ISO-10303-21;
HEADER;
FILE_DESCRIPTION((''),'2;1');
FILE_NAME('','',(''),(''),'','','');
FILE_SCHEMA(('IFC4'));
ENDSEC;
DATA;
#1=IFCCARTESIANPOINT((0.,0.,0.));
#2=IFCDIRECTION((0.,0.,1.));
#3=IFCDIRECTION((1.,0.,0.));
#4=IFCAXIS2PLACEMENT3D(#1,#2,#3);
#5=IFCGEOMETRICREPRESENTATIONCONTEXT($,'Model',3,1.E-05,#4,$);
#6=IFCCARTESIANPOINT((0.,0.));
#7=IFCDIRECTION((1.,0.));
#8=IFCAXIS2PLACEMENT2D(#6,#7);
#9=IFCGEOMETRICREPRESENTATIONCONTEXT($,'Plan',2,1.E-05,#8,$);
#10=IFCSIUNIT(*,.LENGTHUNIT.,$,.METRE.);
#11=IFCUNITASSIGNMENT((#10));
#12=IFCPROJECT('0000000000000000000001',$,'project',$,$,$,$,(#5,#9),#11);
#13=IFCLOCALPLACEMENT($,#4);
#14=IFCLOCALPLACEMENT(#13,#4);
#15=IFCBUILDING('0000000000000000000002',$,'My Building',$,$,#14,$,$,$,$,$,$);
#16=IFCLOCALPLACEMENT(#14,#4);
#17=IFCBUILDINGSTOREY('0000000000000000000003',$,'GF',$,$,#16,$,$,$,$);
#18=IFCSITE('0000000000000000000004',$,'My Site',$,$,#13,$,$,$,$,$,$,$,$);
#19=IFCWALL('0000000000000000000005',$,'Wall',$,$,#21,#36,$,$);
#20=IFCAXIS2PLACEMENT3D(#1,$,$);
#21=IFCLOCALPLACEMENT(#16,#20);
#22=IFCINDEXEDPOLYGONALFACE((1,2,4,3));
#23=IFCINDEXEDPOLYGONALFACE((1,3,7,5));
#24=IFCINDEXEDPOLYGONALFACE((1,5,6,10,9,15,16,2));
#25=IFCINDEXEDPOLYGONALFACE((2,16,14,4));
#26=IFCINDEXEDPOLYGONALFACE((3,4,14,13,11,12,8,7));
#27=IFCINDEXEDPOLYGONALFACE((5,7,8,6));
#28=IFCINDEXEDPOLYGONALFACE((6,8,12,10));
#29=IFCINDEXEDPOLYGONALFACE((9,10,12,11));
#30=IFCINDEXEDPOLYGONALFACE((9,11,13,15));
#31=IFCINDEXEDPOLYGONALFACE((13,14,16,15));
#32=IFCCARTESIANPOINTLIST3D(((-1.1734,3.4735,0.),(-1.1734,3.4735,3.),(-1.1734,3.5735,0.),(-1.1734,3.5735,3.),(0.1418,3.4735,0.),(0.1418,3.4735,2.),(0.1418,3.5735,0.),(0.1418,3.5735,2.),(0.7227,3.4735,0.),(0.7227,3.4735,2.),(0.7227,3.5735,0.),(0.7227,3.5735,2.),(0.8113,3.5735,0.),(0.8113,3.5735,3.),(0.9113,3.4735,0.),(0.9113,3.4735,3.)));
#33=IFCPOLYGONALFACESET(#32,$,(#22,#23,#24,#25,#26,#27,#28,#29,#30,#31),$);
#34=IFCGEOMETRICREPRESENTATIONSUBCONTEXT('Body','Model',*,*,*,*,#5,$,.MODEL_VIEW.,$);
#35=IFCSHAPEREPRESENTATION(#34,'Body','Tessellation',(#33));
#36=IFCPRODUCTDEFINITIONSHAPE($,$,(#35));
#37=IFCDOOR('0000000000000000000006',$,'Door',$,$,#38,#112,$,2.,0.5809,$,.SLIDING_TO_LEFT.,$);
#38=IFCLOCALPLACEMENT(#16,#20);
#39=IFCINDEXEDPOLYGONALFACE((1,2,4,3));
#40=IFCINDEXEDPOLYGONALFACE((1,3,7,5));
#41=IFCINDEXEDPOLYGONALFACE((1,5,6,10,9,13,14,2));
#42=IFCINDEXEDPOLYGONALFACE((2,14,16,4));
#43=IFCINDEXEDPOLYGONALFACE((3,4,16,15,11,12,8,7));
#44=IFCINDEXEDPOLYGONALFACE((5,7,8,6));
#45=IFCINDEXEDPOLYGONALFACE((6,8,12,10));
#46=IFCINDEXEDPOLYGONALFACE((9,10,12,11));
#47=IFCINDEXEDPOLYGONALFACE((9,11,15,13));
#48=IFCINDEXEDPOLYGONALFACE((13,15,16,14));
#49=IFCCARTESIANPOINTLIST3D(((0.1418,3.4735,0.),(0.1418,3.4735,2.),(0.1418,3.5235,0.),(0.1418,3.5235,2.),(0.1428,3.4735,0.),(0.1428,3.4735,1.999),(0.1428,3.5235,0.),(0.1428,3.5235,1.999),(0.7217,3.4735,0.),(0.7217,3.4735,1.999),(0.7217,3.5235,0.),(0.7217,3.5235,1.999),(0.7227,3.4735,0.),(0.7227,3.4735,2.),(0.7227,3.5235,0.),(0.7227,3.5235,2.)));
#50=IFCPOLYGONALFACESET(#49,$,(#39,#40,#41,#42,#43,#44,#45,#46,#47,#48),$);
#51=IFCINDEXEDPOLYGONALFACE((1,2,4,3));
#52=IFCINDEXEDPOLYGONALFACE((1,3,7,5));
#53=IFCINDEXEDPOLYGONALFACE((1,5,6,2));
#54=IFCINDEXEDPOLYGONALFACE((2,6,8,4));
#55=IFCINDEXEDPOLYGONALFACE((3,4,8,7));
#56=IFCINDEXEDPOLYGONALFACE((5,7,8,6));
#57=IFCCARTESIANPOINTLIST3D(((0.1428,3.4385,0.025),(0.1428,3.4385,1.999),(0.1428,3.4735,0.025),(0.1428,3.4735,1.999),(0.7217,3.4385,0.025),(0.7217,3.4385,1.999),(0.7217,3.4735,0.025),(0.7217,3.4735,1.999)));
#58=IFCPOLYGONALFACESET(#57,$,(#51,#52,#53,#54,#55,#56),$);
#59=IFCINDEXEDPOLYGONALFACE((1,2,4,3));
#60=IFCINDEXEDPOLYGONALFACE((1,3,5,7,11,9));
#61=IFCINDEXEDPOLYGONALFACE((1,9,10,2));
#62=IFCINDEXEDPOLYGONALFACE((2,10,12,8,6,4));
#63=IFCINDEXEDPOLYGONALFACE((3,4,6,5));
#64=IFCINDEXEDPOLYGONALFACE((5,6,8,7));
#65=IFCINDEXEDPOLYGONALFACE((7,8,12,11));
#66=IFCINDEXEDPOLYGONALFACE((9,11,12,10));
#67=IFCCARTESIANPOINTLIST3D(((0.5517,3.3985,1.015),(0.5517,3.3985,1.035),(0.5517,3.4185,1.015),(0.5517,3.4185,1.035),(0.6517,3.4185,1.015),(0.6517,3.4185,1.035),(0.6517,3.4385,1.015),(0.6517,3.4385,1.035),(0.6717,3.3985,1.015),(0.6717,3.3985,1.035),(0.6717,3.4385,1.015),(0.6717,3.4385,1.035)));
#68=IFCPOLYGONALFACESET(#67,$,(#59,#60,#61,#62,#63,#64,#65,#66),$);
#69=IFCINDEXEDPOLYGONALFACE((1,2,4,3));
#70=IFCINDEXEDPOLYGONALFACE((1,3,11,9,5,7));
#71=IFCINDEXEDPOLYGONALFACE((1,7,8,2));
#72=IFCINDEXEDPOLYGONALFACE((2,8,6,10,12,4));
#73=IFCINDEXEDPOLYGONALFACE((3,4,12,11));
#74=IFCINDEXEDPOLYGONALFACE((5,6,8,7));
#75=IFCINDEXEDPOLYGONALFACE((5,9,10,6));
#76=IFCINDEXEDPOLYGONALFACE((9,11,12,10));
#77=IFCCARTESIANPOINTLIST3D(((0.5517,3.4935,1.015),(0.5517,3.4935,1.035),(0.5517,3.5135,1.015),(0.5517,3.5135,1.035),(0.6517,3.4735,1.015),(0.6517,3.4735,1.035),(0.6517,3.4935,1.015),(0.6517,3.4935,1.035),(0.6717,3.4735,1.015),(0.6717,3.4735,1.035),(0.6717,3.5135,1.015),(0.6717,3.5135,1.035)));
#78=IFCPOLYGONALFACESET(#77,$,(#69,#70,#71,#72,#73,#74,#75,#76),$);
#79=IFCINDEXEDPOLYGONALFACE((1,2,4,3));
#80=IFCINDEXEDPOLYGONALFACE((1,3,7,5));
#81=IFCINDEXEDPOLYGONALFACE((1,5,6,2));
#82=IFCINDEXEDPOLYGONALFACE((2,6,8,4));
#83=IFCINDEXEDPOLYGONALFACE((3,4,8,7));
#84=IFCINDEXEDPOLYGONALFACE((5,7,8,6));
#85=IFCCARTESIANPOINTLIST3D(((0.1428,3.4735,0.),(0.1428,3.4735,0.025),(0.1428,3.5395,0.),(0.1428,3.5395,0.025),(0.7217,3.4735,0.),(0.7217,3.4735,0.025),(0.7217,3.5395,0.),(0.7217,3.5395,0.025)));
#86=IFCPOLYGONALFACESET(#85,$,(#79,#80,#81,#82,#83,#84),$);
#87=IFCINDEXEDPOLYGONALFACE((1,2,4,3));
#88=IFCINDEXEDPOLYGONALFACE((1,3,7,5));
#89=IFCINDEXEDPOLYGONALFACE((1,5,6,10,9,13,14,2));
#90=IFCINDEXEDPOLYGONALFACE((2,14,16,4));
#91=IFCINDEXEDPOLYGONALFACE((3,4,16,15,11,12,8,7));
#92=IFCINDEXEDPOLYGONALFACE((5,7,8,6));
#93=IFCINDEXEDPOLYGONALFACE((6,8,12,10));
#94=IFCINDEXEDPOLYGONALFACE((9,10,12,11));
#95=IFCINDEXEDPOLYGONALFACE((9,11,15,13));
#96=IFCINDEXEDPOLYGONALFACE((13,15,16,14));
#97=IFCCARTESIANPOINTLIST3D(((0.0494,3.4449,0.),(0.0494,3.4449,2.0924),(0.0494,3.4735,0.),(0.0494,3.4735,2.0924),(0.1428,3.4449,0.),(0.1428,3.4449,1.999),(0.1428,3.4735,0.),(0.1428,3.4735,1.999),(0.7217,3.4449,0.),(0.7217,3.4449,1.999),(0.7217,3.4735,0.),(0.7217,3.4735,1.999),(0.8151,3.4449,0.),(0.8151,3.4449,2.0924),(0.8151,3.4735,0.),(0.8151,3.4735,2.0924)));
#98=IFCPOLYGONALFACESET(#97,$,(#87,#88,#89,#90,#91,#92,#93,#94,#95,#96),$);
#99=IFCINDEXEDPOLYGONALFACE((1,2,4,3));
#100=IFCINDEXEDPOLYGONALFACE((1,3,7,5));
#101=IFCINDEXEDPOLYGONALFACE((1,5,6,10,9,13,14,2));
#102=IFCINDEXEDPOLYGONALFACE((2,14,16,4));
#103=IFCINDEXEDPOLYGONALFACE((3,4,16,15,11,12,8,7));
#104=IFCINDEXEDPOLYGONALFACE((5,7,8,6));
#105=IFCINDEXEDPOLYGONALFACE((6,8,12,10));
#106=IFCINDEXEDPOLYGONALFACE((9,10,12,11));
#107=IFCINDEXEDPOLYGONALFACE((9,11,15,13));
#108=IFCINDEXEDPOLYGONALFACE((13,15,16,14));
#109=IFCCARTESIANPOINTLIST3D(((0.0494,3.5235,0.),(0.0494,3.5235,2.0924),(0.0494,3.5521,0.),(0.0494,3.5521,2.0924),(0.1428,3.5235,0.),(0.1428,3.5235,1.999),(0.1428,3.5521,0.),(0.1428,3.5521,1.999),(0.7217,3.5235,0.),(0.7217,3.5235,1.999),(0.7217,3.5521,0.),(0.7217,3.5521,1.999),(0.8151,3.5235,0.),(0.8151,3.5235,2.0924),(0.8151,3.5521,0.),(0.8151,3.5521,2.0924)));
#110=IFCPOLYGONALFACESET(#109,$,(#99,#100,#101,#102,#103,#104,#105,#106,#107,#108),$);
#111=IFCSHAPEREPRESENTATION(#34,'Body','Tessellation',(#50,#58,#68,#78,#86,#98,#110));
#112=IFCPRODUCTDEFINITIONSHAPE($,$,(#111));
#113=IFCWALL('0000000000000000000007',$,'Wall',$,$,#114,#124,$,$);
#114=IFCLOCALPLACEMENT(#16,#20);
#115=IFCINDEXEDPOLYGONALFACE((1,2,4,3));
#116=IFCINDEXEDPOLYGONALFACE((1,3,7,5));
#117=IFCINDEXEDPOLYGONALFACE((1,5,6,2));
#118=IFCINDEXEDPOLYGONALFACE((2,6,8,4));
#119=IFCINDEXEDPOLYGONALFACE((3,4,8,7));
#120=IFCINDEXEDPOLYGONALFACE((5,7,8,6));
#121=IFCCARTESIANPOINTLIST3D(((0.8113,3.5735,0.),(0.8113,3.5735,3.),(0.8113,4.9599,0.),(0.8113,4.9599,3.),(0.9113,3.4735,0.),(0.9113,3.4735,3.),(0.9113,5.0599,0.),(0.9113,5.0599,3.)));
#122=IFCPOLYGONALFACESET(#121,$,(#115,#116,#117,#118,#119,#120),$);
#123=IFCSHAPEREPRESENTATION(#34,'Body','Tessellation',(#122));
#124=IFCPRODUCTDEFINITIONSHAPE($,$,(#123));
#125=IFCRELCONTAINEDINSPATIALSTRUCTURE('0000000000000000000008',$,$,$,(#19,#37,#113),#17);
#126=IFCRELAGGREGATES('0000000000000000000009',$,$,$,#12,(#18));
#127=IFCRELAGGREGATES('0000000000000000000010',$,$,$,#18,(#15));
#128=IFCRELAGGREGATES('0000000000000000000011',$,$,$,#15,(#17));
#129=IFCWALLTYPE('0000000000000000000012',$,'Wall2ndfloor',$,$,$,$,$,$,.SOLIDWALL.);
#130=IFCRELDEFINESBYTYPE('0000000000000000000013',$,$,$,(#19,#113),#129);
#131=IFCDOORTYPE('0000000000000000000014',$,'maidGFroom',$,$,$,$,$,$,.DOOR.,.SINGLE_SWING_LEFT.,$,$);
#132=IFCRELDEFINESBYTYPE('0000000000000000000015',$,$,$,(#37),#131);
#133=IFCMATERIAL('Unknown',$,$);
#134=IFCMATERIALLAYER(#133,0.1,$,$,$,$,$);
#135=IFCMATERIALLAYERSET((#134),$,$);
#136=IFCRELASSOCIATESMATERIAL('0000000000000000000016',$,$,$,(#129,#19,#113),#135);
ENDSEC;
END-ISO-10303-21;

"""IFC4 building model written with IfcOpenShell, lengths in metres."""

from ifc_helpers import new_model, entity, si_unit, frame, origin_with_axes, origin_2d_with_axis, place, context, subcontext, project, spatial, line, indexed_curve, outline, extrude, shape, source, transform, mapped, material, layer, layer_set, layer_usage, type_object, type_shapes, element, fill, save


model = new_model("IFC4")

# Units and contexts
model_context = context("Model", 3, precision=1e-05, world=origin_with_axes())
plan_context = context("Plan", 2, precision=1e-05, world=origin_2d_with_axis())
body_context_1 = subcontext(model_context, "Body", "Model", "MODEL_VIEW")
body_context_2 = subcontext(plan_context, "Body", "Plan", "PLAN_VIEW")
ifc_project = project(units=[si_unit("LENGTHUNIT", "METRE")], contexts=[model_context, plan_context])

# Site, building, storey
site_placement = place(None, origin_with_axes())
site = spatial("IfcSite", under=ifc_project, at=site_placement, Name="My Site")
building_placement = place(site_placement, origin_with_axes())
building = spatial("IfcBuilding", under=site, at=building_placement, Name="My Building")
storey_placement = place(building_placement, origin_with_axes())
storey = spatial("IfcBuildingStorey", under=building, at=storey_placement, Name="GF")

# Shared definitions
ifc_material = material(Name="Unknown")

# Shared definitions
ifc_layer_1 = layer(ifc_material, 0.1)
ifc_layer_set_1 = layer_set([ifc_layer_1])
wall_type = type_object("IfcWallType", Name="Wall2ndfloor", PredefinedType="SOLIDWALL", material=ifc_layer_set_1)

# Wall, opening, door
ifc_layer_usage_1 = layer_usage(ifc_layer_set_1, "AXIS2", "POSITIVE", 0.0)
wall_1_placement = place(storey_placement, frame((0.9113, 3.5735, 0.0), z_axis=(0.0, 0.0, 1.0), x_axis=(-1.0, 0.0, 0.0)))
wall_1 = element("IfcWall", 1, at=wall_1_placement, inside=storey, type_object=wall_type, material=ifc_layer_usage_1, Name="Wall", context=body_context_1, shape_type="SweptSolid", body=[
    extrude(outline(indexed_curve([(0.1, 0.0), (0.0, 0.1), (2.0847, 0.1), (2.0847, 0.0)], segments=[line(1, 2, 3, 4, 1)])), origin_with_axes(), (0.0, 0.0, 1.0), 3.0),
])
shared_shape_1 = source(origin_with_axes(), body_context_1, "Body", "SweptSolid", [
    extrude(outline(indexed_curve([(0.0, 0.0), (0.5809, 0.0), (0.5809, 2.0), (0.0, 2.0)], segments=[line(1, 2, 3, 4, 1)])), frame((0.0, -0.6, 0.0), z_axis=(0.0, -1.0, 0.0), x_axis=(1.0, 0.0, 0.0)), (0.0, 0.0, -1.0), 1.2),
])
opening_1_placement = place(wall_1_placement, frame((0.7695, 0.1, 0.0), z_axis=(0.0, 0.0, 1.0), x_axis=(-1.0, 0.0, 0.0)))
opening_1 = element("IfcOpeningElement", 2, at=opening_1_placement, cuts=wall_1, PredefinedType="OPENING", context=body_context_1, shape_type="MappedRepresentation", body=[
    mapped(shared_shape_1, transform((0.0, 0.0, 0.0), x_axis=(1.0, 0.0, 0.0), y_axis=(0.0, 1.0, 0.0), z_axis=(0.0, 0.0, 1.0), scale=1.0)),
])
door_type_1 = type_object("IfcDoorType", Name="maidGFroom", OperationType="SINGLE_SWING_LEFT", PredefinedType="DOOR")
shared_shape_2 = source(origin_with_axes(), body_context_1, "Body", "SweptSolid", [
    extrude(outline(indexed_curve([(0.0, 0.0), (0.0, 2.0), (0.5809, 2.0), (0.5809, 0.0), (0.5799, 0.0), (0.5799, 1.999), (0.001, 1.999), (0.001, 0.0)], segments=[line(1, 2, 3, 4, 5, 6, 7, 8, 1)])), frame((0.0, 0.0, 0.0), z_axis=(0.0, -1.0, 0.0), x_axis=(1.0, 0.0, 0.0)), (0.0, 0.0, -1.0), 0.05),
    extrude(outline(indexed_curve([(0.0, 0.0), (0.5789, 0.0), (0.5789, 0.035), (0.0, 0.035)], segments=[line(1, 2, 3, 4, 1)])), frame((0.001, -0.035, 0.025), z_axis=(0.0, 0.0, 1.0), x_axis=(1.0, 0.0, 0.0)), (0.0, 0.0, 1.0), 1.974),
    extrude(outline(indexed_curve([(0.0, 0.0), (0.0, -0.04), (-0.12, -0.04), (-0.12, -0.02), (-0.02, -0.02), (-0.02, 0.0)], segments=[line(1, 2, 3, 4, 5, 6, 1)])), frame((0.5299, -0.035, 1.015), z_axis=(0.0, 0.0, 1.0), x_axis=(1.0, 0.0, 0.0)), (0.0, 0.0, 1.0), 0.02),
    extrude(outline(indexed_curve([(0.0, 0.0), (0.0, 0.04), (-0.12, 0.04), (-0.12, 0.02), (-0.02, 0.02), (-0.02, 0.0)], segments=[line(1, 2, 3, 4, 5, 6, 1)])), frame((0.5299, 0.0, 1.015), z_axis=(0.0, 0.0, 1.0), x_axis=(1.0, 0.0, 0.0)), (0.0, 0.0, 1.0), 0.02),
    extrude(outline(indexed_curve([(0.0, 0.0), (0.5789, 0.0), (0.5789, 0.066), (0.0, 0.066)], segments=[line(1, 2, 3, 4, 1)])), frame((0.001, 0.0, 0.0), z_axis=(0.0, 0.0, 1.0), x_axis=(1.0, 0.0, 0.0)), (0.0, 0.0, 1.0), 0.025),
    extrude(outline(indexed_curve([(0.0, 0.0), (0.0, 2.0924), (0.7656, 2.0924), (0.7656, 0.0), (0.6723, 0.0), (0.6723, 1.999), (0.0934, 1.999), (0.0934, 0.0)], segments=[line(1, 2, 3, 4, 5, 6, 7, 8, 1)])), frame((-0.0924, -0.0286, 0.0), z_axis=(0.0, -1.0, 0.0), x_axis=(1.0, 0.0, 0.0)), (0.0, 0.0, -1.0), 0.0286),
    extrude(outline(indexed_curve([(0.0, 0.0), (0.0, 2.0924), (0.7656, 2.0924), (0.7656, 0.0), (0.6723, 0.0), (0.6723, 1.999), (0.0934, 1.999), (0.0934, 0.0)], segments=[line(1, 2, 3, 4, 5, 6, 7, 8, 1)])), frame((-0.0924, 0.05, 0.0), z_axis=(0.0, -1.0, 0.0), x_axis=(1.0, 0.0, 0.0)), (0.0, 0.0, -1.0), 0.0286),
])
shared_shape_3 = source(origin_with_axes(), body_context_2, "Body", "Curve2D", [
    entity("IfcIndexedPolyCurve", entity("IfcCartesianPointList2D", [[0.0, 0.0], [0.001, 0.0], [0.001, 0.05], [0.0, 0.05]]), [entity("IfcLineIndex", [1, 2, 3, 4, 1])]),
    entity("IfcIndexedPolyCurve", entity("IfcCartesianPointList2D", [[0.5809, 0.0], [0.5799, 0.0], [0.5799, 0.05], [0.5809, 0.05]]), [entity("IfcLineIndex", [1, 2, 3, 4, 1])]),
    entity("IfcIndexedPolyCurve", entity("IfcCartesianPointList2D", [[-0.2884, -0.035], [0.2904, -0.035], [0.2904, 0.0], [-0.2884, 0.0]]), [entity("IfcLineIndex", [1, 2, 3, 4, 1])]),
])
type_shapes(door_type_1, [shared_shape_2, shared_shape_3])
door_1_placement = place(opening_1_placement, frame((0.0, 0.0, 0.0), z_axis=(0.0, 0.0, 1.0), x_axis=(1.0, 0.0, 0.0)))
door_1 = element("IfcDoor", 3, at=door_1_placement, inside=storey, type_object=door_type_1, Name="Door", OperationType="SLIDING_TO_LEFT", OverallHeight=2.0, OverallWidth=0.5809, shapes=[
    shape(body_context_1, "Body", "MappedRepresentation", [mapped(shared_shape_2, transform((0.0, 0.0, 0.0), x_axis=(1.0, 0.0, 0.0), y_axis=(0.0, 1.0, 0.0), z_axis=(0.0, 0.0, 1.0), scale=1.0))]),
    shape(body_context_2, "Body", "MappedRepresentation", [mapped(shared_shape_3, transform((0.0, 0.0, 0.0), x_axis=(1.0, 0.0, 0.0), y_axis=(0.0, 1.0, 0.0), z_axis=(0.0, 0.0, 1.0), scale=1.0))]),
])
fill(opening_1, door_1)

# Wall
ifc_layer_usage_2 = layer_usage(ifc_layer_set_1, "AXIS2", "POSITIVE", 0.0)
wall_2_placement = place(storey_placement, frame((0.9113, 3.5735, 0.0), z_axis=(0.0, 0.0, 1.0), x_axis=(0.0, 1.0, 0.0)))
element("IfcWall", 4, at=wall_2_placement, inside=storey, type_object=wall_type, material=ifc_layer_usage_2, Name="Wall", context=body_context_1, shape_type="SweptSolid", body=[
    extrude(outline(indexed_curve([(-0.1, 0.0), (0.0, 0.1), (1.3864, 0.1), (1.4864, 0.0)], segments=[line(1, 2, 3, 4, 1)])), origin_with_axes(), (0.0, 0.0, 1.0), 3.0),
])

save(model, "model.ifc")
